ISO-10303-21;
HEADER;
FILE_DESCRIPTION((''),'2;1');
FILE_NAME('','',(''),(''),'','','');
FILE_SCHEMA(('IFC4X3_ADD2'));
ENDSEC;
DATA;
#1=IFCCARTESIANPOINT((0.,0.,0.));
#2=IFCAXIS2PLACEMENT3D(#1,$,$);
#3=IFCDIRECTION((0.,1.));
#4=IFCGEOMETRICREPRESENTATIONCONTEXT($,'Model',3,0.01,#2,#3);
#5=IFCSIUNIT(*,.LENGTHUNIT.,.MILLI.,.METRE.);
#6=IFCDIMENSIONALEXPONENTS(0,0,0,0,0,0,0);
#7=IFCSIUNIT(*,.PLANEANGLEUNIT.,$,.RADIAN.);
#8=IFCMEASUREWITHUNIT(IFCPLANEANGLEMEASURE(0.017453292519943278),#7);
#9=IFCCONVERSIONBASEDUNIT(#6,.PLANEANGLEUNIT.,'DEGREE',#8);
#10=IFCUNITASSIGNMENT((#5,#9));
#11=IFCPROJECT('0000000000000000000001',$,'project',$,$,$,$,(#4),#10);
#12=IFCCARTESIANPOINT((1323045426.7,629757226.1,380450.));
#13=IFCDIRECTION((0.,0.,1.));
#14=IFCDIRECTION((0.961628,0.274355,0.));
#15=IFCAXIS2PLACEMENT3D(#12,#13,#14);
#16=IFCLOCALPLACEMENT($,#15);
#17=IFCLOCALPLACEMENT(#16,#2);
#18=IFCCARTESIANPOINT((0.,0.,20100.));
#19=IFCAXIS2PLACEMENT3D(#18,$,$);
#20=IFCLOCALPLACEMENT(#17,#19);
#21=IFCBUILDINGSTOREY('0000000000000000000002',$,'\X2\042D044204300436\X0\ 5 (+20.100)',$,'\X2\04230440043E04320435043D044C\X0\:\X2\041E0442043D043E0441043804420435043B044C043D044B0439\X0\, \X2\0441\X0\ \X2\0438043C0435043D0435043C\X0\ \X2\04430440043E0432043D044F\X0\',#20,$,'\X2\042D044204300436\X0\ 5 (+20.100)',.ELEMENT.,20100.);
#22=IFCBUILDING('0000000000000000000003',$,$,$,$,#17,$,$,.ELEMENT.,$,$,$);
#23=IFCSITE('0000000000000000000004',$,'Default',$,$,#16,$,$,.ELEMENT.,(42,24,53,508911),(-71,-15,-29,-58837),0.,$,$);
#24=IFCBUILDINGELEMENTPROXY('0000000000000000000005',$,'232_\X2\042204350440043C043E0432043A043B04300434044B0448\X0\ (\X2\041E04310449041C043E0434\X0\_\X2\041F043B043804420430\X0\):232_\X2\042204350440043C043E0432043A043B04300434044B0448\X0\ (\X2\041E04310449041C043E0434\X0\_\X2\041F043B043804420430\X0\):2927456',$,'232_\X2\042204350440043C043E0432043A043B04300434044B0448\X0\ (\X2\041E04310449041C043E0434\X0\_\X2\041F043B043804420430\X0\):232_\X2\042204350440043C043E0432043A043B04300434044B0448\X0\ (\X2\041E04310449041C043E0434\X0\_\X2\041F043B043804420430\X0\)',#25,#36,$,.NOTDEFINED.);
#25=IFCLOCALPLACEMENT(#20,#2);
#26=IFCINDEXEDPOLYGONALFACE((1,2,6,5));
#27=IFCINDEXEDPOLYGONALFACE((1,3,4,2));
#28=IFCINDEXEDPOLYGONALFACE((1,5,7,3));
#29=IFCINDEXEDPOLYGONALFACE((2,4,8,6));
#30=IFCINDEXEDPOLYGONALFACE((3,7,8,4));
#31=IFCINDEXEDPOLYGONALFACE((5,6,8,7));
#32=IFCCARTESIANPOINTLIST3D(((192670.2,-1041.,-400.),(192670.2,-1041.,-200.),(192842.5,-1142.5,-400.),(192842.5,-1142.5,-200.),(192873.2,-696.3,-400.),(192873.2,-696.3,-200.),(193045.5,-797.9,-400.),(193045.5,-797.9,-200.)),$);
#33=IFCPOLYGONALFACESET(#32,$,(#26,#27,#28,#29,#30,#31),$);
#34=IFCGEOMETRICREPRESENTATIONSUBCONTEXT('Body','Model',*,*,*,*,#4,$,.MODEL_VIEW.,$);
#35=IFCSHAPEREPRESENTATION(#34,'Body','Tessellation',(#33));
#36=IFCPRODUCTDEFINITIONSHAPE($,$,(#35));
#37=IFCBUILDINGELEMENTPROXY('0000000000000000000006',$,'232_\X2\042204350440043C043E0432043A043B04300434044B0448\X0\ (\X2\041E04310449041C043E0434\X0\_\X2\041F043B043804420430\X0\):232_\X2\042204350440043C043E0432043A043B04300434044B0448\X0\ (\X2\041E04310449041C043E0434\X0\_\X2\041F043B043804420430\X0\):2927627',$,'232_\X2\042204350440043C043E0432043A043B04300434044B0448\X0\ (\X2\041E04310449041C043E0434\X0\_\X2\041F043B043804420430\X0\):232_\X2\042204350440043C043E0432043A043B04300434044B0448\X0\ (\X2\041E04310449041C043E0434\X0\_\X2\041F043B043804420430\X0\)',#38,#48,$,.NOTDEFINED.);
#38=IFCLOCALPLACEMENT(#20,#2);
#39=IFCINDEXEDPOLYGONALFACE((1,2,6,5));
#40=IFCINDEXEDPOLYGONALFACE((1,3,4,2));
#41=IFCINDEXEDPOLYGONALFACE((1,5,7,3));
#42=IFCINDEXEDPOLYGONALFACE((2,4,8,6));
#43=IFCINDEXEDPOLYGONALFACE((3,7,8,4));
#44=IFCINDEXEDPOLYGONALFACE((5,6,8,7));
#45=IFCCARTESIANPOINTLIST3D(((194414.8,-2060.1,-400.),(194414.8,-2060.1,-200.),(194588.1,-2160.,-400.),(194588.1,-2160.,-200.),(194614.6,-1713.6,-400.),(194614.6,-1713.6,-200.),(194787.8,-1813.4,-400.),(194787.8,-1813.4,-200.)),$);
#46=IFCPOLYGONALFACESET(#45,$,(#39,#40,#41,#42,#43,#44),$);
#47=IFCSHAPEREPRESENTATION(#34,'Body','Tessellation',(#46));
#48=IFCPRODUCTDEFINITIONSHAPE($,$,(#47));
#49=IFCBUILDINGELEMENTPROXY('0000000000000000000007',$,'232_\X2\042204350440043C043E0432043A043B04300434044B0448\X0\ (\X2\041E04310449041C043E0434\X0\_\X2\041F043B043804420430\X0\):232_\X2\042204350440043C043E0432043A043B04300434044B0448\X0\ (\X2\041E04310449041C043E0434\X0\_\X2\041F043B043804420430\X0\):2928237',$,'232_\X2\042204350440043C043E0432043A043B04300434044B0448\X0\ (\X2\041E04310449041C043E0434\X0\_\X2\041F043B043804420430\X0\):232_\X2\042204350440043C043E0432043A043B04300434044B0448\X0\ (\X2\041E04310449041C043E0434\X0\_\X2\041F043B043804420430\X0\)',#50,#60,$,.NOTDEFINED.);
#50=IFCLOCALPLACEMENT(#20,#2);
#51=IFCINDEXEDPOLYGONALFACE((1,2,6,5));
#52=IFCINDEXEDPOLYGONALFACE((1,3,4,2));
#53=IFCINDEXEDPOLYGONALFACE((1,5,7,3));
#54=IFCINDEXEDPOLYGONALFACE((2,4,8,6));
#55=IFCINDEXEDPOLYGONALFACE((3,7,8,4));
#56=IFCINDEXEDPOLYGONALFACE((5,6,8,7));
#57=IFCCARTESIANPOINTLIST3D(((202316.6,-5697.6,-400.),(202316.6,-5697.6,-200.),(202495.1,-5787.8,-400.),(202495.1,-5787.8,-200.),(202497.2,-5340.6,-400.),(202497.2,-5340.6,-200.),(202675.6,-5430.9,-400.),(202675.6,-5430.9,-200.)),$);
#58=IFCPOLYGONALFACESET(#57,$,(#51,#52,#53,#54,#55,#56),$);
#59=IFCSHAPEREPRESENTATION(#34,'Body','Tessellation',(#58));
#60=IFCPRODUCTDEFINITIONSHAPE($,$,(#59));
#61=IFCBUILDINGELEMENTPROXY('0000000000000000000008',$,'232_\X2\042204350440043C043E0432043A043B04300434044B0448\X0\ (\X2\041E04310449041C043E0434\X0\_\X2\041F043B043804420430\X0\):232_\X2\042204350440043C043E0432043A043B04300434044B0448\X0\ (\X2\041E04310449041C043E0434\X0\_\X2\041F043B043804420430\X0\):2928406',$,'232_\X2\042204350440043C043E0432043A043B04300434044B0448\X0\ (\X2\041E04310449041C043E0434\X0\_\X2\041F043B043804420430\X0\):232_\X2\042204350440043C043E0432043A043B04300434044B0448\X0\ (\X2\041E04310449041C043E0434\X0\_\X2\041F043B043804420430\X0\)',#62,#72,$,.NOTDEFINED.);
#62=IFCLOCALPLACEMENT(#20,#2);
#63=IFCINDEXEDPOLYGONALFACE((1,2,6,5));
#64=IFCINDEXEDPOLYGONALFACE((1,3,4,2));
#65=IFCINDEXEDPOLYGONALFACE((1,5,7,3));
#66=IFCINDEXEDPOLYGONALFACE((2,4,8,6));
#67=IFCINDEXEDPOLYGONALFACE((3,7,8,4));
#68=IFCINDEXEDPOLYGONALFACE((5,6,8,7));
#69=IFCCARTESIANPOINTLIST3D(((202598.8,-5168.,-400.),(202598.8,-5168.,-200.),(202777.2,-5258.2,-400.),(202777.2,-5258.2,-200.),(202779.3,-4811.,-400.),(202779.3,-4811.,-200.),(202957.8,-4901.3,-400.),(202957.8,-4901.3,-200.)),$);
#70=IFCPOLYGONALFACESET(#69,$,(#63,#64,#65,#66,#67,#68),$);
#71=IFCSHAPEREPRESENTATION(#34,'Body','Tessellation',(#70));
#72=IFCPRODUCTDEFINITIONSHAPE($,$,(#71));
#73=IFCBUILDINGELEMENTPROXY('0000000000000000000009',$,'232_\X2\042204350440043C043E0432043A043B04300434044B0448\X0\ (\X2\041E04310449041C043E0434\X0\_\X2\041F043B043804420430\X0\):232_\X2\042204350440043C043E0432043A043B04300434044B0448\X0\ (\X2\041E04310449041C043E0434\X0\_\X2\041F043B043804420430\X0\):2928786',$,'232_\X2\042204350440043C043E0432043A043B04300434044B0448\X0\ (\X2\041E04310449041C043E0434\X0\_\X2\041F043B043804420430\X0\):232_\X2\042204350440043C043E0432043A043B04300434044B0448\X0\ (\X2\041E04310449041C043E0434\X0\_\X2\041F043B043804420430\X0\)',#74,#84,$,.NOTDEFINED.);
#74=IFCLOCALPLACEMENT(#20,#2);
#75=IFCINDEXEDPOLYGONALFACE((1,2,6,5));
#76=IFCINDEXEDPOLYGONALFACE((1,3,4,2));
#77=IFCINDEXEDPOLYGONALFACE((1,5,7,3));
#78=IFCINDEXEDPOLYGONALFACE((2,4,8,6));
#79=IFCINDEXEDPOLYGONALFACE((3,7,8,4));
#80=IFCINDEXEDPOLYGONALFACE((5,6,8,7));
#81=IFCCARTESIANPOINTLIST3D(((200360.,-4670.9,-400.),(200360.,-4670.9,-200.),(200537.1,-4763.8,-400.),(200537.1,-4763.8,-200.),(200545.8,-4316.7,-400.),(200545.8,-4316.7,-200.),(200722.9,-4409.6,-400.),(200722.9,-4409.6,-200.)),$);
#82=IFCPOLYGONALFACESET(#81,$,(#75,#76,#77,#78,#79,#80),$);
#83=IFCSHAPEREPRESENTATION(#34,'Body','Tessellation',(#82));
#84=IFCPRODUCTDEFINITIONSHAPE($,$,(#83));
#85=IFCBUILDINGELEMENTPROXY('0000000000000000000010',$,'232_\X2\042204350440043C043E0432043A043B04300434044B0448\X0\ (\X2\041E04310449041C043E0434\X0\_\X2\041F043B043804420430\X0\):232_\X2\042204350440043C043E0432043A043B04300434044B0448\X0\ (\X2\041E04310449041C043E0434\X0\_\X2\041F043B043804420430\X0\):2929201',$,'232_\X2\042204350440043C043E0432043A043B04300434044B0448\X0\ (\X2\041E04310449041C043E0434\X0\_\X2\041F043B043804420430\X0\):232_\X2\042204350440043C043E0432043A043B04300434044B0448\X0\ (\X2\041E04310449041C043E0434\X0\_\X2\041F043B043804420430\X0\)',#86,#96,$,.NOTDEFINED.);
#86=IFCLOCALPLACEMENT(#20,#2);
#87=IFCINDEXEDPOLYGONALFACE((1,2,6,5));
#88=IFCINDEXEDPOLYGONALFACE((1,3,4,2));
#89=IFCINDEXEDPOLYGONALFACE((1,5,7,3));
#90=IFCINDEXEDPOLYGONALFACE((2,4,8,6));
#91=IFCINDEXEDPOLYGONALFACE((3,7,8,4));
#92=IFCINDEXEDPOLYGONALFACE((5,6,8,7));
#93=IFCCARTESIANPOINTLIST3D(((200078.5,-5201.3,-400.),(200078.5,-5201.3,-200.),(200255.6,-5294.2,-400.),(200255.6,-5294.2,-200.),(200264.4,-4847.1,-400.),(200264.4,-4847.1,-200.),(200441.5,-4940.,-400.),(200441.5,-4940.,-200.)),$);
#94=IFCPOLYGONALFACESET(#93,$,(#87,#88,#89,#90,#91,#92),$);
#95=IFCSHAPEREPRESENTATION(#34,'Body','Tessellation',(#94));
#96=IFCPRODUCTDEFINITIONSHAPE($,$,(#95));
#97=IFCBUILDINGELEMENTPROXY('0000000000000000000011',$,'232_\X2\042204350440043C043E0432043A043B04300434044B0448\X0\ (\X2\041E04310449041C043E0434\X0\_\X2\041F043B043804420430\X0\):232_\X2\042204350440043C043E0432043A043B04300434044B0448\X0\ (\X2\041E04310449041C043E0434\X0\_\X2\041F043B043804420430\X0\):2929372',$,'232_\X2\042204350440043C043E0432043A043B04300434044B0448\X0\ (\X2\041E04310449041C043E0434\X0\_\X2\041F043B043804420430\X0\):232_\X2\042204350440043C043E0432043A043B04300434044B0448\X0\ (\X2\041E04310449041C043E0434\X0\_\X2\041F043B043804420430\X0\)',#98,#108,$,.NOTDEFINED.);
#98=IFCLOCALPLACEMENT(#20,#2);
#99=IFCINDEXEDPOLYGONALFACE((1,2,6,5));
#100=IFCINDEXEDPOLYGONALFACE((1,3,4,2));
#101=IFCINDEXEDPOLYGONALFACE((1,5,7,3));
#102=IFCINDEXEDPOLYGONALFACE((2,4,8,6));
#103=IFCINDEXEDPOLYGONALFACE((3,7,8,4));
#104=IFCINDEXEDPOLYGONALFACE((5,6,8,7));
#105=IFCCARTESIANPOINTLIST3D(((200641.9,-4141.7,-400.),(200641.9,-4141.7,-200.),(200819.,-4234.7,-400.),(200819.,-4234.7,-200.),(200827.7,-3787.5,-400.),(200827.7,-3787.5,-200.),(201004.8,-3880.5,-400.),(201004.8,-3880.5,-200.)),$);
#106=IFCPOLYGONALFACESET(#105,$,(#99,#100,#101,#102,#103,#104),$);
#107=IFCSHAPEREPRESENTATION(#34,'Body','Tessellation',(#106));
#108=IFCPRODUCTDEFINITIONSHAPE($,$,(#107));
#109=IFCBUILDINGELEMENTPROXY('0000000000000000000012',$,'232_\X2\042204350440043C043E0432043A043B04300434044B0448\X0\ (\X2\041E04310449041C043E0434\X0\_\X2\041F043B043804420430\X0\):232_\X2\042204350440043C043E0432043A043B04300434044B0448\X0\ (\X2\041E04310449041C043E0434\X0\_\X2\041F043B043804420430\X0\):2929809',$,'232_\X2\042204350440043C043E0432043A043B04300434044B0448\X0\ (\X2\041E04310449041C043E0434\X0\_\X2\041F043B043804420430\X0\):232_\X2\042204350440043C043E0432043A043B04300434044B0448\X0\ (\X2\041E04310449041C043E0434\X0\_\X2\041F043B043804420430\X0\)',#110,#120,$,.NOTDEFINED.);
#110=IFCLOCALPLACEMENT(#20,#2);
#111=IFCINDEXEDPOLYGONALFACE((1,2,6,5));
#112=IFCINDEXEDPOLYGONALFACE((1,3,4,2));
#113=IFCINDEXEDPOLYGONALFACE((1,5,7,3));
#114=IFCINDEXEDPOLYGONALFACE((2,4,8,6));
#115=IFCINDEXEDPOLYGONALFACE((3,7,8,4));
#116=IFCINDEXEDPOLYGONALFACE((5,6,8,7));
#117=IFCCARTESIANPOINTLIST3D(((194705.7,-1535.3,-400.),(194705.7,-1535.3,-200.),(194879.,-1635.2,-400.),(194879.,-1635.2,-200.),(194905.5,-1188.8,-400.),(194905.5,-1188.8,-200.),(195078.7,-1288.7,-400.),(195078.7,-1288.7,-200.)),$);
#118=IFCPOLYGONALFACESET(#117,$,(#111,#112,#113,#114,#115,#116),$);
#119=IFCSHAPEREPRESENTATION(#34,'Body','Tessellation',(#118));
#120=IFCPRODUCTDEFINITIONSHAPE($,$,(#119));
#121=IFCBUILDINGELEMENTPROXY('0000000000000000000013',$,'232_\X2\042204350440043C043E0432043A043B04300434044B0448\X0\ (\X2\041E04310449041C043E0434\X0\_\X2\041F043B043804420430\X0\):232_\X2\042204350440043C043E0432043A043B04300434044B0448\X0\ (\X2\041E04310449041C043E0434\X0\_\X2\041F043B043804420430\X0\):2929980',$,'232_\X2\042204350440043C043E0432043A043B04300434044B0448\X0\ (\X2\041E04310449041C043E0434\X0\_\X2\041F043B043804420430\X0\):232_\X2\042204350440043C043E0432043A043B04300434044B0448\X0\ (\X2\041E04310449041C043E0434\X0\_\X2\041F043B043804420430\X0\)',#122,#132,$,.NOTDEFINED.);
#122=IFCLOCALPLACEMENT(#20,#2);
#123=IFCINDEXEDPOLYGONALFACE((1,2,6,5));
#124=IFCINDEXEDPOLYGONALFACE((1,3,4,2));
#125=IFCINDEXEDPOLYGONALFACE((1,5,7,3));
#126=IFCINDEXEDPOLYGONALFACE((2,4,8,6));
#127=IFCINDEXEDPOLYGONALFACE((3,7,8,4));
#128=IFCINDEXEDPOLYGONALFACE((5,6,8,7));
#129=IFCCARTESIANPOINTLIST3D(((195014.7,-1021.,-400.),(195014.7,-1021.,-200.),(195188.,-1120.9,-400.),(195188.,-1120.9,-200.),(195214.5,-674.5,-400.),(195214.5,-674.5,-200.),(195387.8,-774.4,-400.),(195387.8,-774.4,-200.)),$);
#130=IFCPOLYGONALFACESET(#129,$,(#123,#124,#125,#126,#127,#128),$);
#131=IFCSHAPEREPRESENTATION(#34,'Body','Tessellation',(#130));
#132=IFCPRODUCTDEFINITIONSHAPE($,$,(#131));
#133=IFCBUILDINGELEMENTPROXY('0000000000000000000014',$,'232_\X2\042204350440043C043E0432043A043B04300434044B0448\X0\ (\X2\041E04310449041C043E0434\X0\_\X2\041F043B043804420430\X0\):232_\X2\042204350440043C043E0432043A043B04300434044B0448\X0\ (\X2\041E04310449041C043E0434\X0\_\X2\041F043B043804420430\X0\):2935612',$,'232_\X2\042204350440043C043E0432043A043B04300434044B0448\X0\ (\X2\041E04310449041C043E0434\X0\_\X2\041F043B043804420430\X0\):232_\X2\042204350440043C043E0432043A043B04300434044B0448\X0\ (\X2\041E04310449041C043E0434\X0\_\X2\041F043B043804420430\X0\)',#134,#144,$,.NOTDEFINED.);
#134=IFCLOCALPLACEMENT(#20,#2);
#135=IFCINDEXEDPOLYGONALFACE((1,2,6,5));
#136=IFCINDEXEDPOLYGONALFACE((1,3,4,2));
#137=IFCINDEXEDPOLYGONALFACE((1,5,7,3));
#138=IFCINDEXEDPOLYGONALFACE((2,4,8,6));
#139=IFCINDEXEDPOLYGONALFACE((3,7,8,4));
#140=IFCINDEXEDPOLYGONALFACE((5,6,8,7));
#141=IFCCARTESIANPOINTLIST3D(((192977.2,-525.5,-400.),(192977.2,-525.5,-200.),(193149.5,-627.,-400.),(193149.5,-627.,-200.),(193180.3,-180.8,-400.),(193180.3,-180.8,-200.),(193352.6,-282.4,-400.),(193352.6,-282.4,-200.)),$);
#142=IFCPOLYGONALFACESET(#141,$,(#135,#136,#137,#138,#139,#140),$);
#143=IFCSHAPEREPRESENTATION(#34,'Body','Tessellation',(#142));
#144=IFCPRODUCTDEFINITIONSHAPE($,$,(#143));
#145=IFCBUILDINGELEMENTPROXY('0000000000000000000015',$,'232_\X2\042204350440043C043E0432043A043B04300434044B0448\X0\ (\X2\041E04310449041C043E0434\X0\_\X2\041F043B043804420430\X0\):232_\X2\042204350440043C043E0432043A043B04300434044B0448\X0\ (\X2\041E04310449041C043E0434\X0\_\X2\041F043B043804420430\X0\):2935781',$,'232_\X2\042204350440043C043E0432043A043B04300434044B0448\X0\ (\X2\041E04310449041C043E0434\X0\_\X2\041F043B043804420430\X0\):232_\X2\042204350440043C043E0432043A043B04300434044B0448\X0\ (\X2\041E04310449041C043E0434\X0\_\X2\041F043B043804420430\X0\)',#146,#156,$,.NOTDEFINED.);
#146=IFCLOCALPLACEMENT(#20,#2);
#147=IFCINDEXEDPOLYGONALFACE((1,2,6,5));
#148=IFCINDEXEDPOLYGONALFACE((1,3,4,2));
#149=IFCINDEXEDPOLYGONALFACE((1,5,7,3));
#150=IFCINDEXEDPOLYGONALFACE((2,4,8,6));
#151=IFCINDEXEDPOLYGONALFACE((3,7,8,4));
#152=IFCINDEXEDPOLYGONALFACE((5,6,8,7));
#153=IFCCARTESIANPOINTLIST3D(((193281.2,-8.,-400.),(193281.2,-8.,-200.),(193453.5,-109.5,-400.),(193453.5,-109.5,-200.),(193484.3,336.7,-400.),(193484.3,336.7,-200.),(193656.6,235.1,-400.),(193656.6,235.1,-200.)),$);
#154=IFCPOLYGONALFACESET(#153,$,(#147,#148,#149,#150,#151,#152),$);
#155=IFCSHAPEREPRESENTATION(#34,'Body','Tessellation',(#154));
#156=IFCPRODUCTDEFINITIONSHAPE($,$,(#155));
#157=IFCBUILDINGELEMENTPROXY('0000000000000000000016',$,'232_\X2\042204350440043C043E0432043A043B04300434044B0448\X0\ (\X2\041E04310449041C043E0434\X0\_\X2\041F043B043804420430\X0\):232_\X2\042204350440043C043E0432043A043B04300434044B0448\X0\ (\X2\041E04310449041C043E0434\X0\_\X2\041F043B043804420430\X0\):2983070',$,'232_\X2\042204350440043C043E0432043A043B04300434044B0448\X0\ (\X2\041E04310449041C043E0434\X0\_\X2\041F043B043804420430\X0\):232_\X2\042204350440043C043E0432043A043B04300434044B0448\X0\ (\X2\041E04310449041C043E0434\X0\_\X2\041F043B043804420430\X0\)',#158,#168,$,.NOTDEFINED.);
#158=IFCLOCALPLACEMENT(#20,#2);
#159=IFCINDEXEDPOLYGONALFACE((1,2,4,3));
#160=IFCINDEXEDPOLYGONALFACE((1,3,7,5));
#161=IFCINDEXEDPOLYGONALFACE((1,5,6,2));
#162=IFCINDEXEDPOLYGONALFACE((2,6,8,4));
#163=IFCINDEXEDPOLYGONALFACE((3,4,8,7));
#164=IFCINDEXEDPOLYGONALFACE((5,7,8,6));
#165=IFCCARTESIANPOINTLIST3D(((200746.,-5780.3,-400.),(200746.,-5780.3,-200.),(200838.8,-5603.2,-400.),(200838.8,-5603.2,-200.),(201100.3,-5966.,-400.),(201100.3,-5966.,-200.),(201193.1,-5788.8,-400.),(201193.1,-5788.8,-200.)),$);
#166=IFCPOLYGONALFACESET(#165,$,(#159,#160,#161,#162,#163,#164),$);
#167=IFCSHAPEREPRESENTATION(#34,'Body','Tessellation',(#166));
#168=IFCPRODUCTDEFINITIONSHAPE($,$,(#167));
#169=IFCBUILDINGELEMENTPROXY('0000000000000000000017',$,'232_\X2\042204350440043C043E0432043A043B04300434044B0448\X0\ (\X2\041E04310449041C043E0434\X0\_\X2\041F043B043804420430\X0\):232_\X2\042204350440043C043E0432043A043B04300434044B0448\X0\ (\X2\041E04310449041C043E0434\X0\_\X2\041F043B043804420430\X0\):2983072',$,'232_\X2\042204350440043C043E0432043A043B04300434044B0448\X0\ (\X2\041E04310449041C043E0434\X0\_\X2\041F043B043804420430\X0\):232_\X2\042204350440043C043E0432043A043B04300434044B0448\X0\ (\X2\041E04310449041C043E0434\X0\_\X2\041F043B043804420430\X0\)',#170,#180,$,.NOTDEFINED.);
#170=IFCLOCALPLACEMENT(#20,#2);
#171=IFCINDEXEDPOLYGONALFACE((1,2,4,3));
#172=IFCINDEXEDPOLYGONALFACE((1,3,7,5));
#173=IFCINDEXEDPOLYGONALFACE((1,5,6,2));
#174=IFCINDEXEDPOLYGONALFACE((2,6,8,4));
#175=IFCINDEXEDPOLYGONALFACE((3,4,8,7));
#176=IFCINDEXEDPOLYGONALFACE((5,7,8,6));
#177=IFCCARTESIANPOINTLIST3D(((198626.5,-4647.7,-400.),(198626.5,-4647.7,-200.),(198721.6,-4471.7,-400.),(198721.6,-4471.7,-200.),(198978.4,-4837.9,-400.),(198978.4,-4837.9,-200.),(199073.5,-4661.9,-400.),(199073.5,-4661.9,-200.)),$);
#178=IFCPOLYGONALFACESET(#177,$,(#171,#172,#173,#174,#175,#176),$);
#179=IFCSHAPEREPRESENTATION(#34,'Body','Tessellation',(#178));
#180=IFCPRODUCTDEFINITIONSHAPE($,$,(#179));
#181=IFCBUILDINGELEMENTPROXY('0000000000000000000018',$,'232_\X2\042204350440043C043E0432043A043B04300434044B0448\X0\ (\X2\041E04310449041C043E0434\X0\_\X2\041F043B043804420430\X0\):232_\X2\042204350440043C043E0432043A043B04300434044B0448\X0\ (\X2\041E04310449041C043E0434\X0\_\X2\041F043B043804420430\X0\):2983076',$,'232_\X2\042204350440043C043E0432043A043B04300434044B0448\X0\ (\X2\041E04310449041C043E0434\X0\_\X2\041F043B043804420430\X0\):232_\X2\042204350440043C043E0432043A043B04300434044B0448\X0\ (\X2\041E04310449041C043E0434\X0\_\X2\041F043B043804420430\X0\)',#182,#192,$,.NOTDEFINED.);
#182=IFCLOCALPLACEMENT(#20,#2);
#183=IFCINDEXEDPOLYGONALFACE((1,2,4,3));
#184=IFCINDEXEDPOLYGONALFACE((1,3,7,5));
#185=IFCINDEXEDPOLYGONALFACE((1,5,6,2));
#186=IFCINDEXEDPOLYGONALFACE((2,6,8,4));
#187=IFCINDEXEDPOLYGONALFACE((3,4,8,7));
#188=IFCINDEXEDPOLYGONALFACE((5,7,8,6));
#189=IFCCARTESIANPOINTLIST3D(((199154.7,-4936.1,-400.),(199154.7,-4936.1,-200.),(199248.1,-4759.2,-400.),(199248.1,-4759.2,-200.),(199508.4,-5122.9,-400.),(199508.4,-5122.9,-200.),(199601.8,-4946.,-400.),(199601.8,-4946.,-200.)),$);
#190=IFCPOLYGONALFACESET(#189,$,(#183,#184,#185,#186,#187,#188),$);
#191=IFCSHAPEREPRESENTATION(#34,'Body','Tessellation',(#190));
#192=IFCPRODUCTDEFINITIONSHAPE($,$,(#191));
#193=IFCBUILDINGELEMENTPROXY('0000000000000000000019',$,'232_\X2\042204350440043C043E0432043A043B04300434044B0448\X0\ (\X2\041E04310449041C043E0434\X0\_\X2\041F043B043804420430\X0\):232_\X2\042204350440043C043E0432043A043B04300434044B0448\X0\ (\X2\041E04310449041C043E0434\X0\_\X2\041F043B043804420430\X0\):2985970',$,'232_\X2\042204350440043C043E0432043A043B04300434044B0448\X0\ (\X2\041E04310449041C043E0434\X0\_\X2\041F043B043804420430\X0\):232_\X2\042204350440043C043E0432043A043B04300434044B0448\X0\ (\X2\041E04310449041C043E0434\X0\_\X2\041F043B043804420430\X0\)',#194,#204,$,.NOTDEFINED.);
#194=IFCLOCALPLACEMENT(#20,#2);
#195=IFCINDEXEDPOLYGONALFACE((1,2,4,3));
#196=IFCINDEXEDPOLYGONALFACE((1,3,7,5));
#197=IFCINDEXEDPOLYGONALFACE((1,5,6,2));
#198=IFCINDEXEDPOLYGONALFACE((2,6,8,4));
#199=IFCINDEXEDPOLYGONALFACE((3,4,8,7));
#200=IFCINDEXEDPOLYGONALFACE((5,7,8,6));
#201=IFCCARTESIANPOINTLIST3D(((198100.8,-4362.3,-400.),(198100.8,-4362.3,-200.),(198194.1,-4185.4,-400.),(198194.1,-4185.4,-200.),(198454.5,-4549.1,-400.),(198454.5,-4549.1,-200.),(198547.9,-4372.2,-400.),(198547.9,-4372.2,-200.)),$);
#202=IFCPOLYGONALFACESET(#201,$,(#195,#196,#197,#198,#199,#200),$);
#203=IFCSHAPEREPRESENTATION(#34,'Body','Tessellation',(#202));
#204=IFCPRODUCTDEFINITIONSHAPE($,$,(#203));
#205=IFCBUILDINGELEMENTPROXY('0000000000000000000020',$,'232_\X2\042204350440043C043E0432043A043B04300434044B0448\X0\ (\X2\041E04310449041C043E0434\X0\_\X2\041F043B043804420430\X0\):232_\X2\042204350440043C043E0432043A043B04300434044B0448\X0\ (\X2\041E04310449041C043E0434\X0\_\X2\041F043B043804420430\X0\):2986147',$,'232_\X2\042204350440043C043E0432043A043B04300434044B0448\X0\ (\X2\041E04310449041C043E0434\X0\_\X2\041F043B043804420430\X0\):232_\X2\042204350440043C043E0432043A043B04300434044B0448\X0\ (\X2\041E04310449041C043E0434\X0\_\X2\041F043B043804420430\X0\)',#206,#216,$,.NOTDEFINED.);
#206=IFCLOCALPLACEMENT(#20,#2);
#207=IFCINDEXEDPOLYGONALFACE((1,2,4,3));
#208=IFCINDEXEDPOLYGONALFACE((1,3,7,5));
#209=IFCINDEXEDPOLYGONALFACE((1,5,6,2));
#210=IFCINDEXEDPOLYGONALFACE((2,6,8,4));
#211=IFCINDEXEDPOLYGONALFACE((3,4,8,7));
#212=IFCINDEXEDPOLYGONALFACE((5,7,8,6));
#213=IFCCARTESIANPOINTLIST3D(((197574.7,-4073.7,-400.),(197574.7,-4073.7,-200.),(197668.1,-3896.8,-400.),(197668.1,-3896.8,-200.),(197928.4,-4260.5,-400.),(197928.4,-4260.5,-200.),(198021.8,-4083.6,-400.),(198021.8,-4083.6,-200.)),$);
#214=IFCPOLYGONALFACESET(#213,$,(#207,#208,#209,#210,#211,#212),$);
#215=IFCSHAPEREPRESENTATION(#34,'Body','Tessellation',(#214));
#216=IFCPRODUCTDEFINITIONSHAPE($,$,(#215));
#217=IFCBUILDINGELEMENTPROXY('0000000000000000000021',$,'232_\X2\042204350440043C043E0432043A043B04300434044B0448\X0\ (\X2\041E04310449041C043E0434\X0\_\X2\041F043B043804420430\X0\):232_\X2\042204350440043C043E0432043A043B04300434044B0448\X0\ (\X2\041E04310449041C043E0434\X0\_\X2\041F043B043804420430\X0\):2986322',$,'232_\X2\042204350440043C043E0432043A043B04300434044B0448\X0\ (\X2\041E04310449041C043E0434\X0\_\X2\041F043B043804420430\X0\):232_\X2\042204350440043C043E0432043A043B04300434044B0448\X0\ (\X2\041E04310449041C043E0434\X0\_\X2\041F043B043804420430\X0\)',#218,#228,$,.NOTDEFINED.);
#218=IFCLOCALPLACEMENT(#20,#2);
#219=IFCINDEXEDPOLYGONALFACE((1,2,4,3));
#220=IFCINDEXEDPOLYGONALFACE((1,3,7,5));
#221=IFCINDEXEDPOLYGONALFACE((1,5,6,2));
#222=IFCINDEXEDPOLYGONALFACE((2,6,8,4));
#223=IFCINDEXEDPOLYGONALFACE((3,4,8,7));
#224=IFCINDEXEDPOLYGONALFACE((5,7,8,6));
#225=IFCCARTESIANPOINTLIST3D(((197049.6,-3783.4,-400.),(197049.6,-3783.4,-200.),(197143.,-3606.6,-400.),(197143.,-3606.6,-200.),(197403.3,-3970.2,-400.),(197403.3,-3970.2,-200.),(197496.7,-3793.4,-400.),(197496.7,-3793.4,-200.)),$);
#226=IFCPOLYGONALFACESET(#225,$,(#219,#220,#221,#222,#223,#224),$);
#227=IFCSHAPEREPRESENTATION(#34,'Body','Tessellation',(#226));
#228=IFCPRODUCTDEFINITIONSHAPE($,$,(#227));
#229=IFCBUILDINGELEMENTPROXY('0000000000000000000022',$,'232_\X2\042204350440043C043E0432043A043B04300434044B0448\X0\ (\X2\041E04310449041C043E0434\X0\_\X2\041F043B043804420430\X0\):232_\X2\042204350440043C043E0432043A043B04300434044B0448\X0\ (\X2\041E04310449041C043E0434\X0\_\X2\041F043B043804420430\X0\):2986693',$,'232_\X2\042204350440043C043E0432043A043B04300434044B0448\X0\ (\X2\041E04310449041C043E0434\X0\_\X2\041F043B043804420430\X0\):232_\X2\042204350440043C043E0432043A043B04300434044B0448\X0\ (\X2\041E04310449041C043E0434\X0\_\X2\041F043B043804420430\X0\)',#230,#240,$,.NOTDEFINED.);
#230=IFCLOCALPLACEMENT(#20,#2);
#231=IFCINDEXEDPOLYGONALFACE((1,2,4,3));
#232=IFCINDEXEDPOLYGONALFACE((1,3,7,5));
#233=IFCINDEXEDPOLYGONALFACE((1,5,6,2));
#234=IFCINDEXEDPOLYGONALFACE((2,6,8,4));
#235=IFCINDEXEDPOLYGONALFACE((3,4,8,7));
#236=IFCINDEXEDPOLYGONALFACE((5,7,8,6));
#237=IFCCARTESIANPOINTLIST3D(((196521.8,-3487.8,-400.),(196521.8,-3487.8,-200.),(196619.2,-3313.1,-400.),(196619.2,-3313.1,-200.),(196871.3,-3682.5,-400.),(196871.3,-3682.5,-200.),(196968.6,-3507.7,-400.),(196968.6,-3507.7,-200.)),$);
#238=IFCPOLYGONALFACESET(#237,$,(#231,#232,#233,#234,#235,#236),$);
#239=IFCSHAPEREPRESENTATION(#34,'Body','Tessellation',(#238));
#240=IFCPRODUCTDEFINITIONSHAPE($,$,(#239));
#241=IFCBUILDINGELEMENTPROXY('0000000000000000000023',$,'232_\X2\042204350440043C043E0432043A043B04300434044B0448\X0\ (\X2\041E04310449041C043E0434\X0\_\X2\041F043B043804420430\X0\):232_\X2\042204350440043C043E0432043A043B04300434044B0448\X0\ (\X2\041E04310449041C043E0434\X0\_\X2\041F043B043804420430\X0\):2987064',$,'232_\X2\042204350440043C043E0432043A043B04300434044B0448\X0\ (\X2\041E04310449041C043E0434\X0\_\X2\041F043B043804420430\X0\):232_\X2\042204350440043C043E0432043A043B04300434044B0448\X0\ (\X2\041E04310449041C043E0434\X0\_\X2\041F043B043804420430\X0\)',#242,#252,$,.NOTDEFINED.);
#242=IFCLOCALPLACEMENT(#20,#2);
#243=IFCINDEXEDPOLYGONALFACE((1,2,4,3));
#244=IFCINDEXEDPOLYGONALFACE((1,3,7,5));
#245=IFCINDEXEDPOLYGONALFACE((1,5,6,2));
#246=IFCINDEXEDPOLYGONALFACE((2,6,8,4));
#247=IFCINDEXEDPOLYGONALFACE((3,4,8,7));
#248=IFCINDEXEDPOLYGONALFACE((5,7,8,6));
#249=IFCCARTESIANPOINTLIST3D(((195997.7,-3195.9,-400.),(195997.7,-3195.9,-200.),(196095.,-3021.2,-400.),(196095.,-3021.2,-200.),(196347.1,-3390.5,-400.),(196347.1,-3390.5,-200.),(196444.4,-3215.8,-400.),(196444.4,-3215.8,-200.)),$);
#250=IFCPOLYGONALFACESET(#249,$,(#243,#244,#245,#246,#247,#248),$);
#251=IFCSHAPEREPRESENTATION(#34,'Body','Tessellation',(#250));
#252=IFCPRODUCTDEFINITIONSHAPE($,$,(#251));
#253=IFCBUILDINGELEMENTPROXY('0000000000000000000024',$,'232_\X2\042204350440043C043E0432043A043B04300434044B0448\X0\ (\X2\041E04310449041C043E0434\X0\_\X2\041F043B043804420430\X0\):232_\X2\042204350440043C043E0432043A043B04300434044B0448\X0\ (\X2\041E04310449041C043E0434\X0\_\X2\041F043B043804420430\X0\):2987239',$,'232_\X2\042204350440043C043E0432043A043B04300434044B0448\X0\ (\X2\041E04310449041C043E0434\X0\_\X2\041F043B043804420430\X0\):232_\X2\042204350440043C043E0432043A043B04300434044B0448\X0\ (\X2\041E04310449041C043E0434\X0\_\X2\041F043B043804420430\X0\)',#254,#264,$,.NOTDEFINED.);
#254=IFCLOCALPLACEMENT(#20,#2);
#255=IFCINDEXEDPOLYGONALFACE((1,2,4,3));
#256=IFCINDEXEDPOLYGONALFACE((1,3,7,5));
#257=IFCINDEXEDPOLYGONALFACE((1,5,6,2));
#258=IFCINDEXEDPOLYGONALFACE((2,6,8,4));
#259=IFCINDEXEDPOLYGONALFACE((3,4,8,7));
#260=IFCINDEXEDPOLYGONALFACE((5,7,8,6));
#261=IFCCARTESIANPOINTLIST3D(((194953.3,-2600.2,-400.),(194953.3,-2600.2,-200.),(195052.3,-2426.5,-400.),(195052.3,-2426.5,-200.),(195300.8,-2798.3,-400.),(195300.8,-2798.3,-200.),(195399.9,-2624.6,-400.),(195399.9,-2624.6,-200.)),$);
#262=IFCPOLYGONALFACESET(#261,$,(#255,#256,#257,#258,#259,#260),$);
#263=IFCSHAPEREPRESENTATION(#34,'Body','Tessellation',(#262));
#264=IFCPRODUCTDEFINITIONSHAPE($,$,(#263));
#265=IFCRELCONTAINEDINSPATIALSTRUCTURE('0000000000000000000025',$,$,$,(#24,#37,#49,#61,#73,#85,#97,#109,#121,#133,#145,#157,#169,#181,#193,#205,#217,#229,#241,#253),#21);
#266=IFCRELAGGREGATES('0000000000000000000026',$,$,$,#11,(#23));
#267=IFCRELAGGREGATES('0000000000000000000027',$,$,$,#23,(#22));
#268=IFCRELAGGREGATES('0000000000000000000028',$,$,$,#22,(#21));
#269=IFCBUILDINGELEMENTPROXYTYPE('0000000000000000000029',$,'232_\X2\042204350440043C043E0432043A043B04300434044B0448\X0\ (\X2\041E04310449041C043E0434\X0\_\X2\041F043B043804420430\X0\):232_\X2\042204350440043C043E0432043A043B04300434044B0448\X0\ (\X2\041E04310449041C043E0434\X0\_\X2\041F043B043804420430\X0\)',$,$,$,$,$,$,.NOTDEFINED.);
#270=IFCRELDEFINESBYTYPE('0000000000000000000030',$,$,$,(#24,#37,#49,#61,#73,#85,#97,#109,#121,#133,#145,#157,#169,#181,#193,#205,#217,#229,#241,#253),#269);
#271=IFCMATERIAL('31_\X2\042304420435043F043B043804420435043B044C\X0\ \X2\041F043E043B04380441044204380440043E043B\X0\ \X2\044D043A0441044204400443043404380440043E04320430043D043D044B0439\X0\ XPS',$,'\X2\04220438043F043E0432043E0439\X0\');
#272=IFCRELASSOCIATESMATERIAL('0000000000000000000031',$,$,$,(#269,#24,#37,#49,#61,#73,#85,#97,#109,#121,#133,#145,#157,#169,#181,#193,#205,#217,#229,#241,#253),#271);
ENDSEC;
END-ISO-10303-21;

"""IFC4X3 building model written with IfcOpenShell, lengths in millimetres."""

from ifc_helpers import new_model, entity, si_unit, converted_unit, direction, frame, origin, origin_2d_with_axis, place, context, subcontext, project, spatial, rectangle, extrude, source, transform, mapped, material, type_object, type_shapes, element, save


model = new_model("IFC4X3")

# Units and contexts
model_context = context("Model", 3, precision=0.01, world=origin(), true_north=direction((0.0, 1.0)))
body_context = subcontext(model_context, "Body", "Model", "MODEL_VIEW")
ifc_project = project(units=[si_unit("LENGTHUNIT", "METRE", prefix="MILLI"), converted_unit("PLANEANGLEUNIT", "DEGREE", entity("IfcPlaneAngleMeasure", 0.017453292519943278), si_unit("PLANEANGLEUNIT", "RADIAN"), dimensions=[0, 0, 0, 0, 0, 0, 0])], contexts=[model_context])

# Site, building, storey
site_placement = place(None, frame((1323045426.7, 629757226.1, 380450.0), z_axis=(0.0, 0.0, 1.0), x_axis=(0.961628, 0.274355, 0.0)))
site = spatial("IfcSite", under=ifc_project, at=site_placement, Name="Default", CompositionType="ELEMENT", RefLatitude=(42, 24, 53, 508911), RefLongitude=(-71, -15, -29, -58837), RefElevation=0.0)
building_placement = place(site_placement, origin())
building = spatial("IfcBuilding", under=site, at=building_placement, CompositionType="ELEMENT")
storey_placement = place(building_placement, frame((0.0, 0.0, 20100.0)))
storey = spatial("IfcBuildingStorey", under=building, at=storey_placement, Name="Этаж 5 (+20.100)", ObjectType="Уровень:Относительный, с именем уровня", LongName="Этаж 5 (+20.100)", CompositionType="ELEMENT", Elevation=20100.0)

# Building element proxies
ifc_material = material(Name="31_Утеплитель Полистирол экструдированный XPS", Category="Типовой")
building_element_proxy_type_1 = type_object("IfcBuildingElementProxyType", Name="232_Термовкладыш (ОбщМод_Плита):232_Термовкладыш (ОбщМод_Плита)", PredefinedType="NOTDEFINED", material=ifc_material)
shared_shape_1 = source(origin(), body_context, "Body", "SweptSolid", [
    extrude(rectangle(XDim=400.0, YDim=200.0, at=origin_2d_with_axis()), frame((200.0, 0.0, -200.0), z_axis=(0.0, 0.0, 1.0), x_axis=(-1.0, 0.0, 0.0)), (0.0, 0.0, 1.0), 200.0),
])
type_shapes(building_element_proxy_type_1, [shared_shape_1])
for number, where, z_axis, x_axis, name in (
    (1, (192756.3, -1091.7, -200.0), (0.0, 0.0, 1.0), (0.507652, 0.861562, 0.0), "232_Термовкладыш (ОбщМод_Плита):232_Термовкладыш (ОбщМод_Плита):2927456"),
    (2, (194501.4, -2110.1, -200.0), (0.0, 0.0, 1.0), (0.499402, 0.86637, 0.0), "232_Термовкладыш (ОбщМод_Плита):232_Термовкладыш (ОбщМод_Плита):2927627"),
    (3, (202405.9, -5742.7, -200.0), (0.0, 0.0, 1.0), (0.451327, 0.892359, 0.0), "232_Термовкладыш (ОбщМод_Плита):232_Термовкладыш (ОбщМод_Плита):2928237"),
    (4, (202688.0, -5213.1, -200.0), (0.0, 0.0, 1.0), (0.451327, 0.892359, 0.0), "232_Термовкладыш (ОбщМод_Плита):232_Термовкладыш (ОбщМод_Плита):2928406"),
    (5, (200448.5, -4717.4, -200.0), (0.0, 0.0, 1.0), (0.464638, 0.885501, 0.0), "232_Термовкладыш (ОбщМод_Плита):232_Термовкладыш (ОбщМод_Плита):2928786"),
    (6, (200167.1, -5247.7, -200.0), (0.0, 0.0, 1.0), (0.464638, 0.885501, 0.0), "232_Термовкладыш (ОбщМод_Плита):232_Термовкладыш (ОбщМод_Плита):2929201"),
    (7, (200730.4, -4188.2, -200.0), (0.0, 0.0, 1.0), (0.464638, 0.885501, 0.0), "232_Термовкладыш (ОбщМод_Плита):232_Термовкладыш (ОбщМод_Плита):2929372"),
    (8, (194792.3, -1585.3, -200.0), (0.0, 0.0, 1.0), (0.499402, 0.86637, 0.0), "232_Термовкладыш (ОбщМод_Плита):232_Термовкладыш (ОбщМод_Плита):2929809"),
    (9, (195101.4, -1071.0, -200.0), (0.0, 0.0, 1.0), (0.499402, 0.86637, 0.0), "232_Термовкладыш (ОбщМод_Плита):232_Термовкладыш (ОбщМод_Плита):2929980"),
    (10, (193063.3, -576.2, -200.0), (0.0, 0.0, 1.0), (0.507652, 0.861562, 0.0), "232_Термовкладыш (ОбщМод_Плита):232_Термовкладыш (ОбщМод_Плита):2935612"),
    (11, (193367.4, -58.7, -200.0), (0.0, 0.0, 1.0), (0.507652, 0.861562, 0.0), "232_Термовкладыш (ОбщМод_Плита):232_Термовкладыш (ОбщМод_Плита):2935781"),
    (12, (201146.7, -5877.4, -200.0), (0.0, 0.0, 1.0), (-0.885773, 0.464119, 0.0), "232_Термовкладыш (ОбщМод_Плита):232_Термовкладыш (ОбщМод_Плита):2983070"),
    (13, (199026.0, -4749.9, -200.0), (0.0, 0.0, 1.0), (-0.879784, 0.475374, 0.0), "232_Термовкладыш (ОбщМод_Плита):232_Термовкладыш (ОбщМод_Плита):2983072"),
    (14, (199555.1, -5034.4, -200.0), (0.0, 0.0, 1.0), (-0.884289, 0.46694, 0.0), "232_Термовкладыш (ОбщМод_Плита):232_Термовкладыш (ОбщМод_Плита):2983076"),
    (15, (198501.2, -4460.6, -200.0), (0.0, 0.0, 1.0), (-0.884289, 0.46694, 0.0), "232_Термовкладыш (ОбщМод_Плита):232_Термовкладыш (ОбщМод_Плита):2985970"),
    (16, (197975.1, -4172.1, -200.0), (0.0, 0.0, 1.0), (-0.884289, 0.46694, 0.0), "232_Термовкладыш (ОбщМод_Плита):232_Термовкладыш (ОбщМод_Плита):2986147"),
    (17, (197450.0, -3881.8, -200.0), (0.0, 0.0, 1.0), (-0.884289, 0.46694, 0.0), "232_Термовкладыш (ОбщМод_Плита):232_Термовкладыш (ОбщМод_Плита):2986322"),
    (18, (196920.0, -3595.1, -200.0), (0.0, 0.0, 1.0), (-0.873652, 0.486551, 0.0), "232_Термовкладыш (ОбщМод_Плита):232_Термовкладыш (ОбщМод_Плита):2986693"),
    (19, (196395.8, -3303.2, -200.0), (0.0, 0.0, 1.0), (-0.873652, 0.486551, 0.0), "232_Термовкладыш (ОбщМод_Плита):232_Термовкладыш (ОбщМод_Плита):2987064"),
    (20, (195350.3, -2711.4, -200.0), (0.0, 0.0, 1.0), (-0.868797, 0.495168, 0.0), "232_Термовкладыш (ОбщМод_Плита):232_Термовкладыш (ОбщМод_Плита):2987239"),
):
    element("IfcBuildingElementProxy", number, at=place(storey_placement, frame(where, z_axis=z_axis, x_axis=x_axis)), inside=storey, type_object=building_element_proxy_type_1, material=ifc_material, Name=name, ObjectType="232_Термовкладыш (ОбщМод_Плита):232_Термовкладыш (ОбщМод_Плита)", PredefinedType="NOTDEFINED", context=body_context, shape_type="MappedRepresentation", body=[
        mapped(shared_shape_1, transform((0.0, 0.0, 0.0), scale=1.0)),
    ])

save(model, "model.ifc")
